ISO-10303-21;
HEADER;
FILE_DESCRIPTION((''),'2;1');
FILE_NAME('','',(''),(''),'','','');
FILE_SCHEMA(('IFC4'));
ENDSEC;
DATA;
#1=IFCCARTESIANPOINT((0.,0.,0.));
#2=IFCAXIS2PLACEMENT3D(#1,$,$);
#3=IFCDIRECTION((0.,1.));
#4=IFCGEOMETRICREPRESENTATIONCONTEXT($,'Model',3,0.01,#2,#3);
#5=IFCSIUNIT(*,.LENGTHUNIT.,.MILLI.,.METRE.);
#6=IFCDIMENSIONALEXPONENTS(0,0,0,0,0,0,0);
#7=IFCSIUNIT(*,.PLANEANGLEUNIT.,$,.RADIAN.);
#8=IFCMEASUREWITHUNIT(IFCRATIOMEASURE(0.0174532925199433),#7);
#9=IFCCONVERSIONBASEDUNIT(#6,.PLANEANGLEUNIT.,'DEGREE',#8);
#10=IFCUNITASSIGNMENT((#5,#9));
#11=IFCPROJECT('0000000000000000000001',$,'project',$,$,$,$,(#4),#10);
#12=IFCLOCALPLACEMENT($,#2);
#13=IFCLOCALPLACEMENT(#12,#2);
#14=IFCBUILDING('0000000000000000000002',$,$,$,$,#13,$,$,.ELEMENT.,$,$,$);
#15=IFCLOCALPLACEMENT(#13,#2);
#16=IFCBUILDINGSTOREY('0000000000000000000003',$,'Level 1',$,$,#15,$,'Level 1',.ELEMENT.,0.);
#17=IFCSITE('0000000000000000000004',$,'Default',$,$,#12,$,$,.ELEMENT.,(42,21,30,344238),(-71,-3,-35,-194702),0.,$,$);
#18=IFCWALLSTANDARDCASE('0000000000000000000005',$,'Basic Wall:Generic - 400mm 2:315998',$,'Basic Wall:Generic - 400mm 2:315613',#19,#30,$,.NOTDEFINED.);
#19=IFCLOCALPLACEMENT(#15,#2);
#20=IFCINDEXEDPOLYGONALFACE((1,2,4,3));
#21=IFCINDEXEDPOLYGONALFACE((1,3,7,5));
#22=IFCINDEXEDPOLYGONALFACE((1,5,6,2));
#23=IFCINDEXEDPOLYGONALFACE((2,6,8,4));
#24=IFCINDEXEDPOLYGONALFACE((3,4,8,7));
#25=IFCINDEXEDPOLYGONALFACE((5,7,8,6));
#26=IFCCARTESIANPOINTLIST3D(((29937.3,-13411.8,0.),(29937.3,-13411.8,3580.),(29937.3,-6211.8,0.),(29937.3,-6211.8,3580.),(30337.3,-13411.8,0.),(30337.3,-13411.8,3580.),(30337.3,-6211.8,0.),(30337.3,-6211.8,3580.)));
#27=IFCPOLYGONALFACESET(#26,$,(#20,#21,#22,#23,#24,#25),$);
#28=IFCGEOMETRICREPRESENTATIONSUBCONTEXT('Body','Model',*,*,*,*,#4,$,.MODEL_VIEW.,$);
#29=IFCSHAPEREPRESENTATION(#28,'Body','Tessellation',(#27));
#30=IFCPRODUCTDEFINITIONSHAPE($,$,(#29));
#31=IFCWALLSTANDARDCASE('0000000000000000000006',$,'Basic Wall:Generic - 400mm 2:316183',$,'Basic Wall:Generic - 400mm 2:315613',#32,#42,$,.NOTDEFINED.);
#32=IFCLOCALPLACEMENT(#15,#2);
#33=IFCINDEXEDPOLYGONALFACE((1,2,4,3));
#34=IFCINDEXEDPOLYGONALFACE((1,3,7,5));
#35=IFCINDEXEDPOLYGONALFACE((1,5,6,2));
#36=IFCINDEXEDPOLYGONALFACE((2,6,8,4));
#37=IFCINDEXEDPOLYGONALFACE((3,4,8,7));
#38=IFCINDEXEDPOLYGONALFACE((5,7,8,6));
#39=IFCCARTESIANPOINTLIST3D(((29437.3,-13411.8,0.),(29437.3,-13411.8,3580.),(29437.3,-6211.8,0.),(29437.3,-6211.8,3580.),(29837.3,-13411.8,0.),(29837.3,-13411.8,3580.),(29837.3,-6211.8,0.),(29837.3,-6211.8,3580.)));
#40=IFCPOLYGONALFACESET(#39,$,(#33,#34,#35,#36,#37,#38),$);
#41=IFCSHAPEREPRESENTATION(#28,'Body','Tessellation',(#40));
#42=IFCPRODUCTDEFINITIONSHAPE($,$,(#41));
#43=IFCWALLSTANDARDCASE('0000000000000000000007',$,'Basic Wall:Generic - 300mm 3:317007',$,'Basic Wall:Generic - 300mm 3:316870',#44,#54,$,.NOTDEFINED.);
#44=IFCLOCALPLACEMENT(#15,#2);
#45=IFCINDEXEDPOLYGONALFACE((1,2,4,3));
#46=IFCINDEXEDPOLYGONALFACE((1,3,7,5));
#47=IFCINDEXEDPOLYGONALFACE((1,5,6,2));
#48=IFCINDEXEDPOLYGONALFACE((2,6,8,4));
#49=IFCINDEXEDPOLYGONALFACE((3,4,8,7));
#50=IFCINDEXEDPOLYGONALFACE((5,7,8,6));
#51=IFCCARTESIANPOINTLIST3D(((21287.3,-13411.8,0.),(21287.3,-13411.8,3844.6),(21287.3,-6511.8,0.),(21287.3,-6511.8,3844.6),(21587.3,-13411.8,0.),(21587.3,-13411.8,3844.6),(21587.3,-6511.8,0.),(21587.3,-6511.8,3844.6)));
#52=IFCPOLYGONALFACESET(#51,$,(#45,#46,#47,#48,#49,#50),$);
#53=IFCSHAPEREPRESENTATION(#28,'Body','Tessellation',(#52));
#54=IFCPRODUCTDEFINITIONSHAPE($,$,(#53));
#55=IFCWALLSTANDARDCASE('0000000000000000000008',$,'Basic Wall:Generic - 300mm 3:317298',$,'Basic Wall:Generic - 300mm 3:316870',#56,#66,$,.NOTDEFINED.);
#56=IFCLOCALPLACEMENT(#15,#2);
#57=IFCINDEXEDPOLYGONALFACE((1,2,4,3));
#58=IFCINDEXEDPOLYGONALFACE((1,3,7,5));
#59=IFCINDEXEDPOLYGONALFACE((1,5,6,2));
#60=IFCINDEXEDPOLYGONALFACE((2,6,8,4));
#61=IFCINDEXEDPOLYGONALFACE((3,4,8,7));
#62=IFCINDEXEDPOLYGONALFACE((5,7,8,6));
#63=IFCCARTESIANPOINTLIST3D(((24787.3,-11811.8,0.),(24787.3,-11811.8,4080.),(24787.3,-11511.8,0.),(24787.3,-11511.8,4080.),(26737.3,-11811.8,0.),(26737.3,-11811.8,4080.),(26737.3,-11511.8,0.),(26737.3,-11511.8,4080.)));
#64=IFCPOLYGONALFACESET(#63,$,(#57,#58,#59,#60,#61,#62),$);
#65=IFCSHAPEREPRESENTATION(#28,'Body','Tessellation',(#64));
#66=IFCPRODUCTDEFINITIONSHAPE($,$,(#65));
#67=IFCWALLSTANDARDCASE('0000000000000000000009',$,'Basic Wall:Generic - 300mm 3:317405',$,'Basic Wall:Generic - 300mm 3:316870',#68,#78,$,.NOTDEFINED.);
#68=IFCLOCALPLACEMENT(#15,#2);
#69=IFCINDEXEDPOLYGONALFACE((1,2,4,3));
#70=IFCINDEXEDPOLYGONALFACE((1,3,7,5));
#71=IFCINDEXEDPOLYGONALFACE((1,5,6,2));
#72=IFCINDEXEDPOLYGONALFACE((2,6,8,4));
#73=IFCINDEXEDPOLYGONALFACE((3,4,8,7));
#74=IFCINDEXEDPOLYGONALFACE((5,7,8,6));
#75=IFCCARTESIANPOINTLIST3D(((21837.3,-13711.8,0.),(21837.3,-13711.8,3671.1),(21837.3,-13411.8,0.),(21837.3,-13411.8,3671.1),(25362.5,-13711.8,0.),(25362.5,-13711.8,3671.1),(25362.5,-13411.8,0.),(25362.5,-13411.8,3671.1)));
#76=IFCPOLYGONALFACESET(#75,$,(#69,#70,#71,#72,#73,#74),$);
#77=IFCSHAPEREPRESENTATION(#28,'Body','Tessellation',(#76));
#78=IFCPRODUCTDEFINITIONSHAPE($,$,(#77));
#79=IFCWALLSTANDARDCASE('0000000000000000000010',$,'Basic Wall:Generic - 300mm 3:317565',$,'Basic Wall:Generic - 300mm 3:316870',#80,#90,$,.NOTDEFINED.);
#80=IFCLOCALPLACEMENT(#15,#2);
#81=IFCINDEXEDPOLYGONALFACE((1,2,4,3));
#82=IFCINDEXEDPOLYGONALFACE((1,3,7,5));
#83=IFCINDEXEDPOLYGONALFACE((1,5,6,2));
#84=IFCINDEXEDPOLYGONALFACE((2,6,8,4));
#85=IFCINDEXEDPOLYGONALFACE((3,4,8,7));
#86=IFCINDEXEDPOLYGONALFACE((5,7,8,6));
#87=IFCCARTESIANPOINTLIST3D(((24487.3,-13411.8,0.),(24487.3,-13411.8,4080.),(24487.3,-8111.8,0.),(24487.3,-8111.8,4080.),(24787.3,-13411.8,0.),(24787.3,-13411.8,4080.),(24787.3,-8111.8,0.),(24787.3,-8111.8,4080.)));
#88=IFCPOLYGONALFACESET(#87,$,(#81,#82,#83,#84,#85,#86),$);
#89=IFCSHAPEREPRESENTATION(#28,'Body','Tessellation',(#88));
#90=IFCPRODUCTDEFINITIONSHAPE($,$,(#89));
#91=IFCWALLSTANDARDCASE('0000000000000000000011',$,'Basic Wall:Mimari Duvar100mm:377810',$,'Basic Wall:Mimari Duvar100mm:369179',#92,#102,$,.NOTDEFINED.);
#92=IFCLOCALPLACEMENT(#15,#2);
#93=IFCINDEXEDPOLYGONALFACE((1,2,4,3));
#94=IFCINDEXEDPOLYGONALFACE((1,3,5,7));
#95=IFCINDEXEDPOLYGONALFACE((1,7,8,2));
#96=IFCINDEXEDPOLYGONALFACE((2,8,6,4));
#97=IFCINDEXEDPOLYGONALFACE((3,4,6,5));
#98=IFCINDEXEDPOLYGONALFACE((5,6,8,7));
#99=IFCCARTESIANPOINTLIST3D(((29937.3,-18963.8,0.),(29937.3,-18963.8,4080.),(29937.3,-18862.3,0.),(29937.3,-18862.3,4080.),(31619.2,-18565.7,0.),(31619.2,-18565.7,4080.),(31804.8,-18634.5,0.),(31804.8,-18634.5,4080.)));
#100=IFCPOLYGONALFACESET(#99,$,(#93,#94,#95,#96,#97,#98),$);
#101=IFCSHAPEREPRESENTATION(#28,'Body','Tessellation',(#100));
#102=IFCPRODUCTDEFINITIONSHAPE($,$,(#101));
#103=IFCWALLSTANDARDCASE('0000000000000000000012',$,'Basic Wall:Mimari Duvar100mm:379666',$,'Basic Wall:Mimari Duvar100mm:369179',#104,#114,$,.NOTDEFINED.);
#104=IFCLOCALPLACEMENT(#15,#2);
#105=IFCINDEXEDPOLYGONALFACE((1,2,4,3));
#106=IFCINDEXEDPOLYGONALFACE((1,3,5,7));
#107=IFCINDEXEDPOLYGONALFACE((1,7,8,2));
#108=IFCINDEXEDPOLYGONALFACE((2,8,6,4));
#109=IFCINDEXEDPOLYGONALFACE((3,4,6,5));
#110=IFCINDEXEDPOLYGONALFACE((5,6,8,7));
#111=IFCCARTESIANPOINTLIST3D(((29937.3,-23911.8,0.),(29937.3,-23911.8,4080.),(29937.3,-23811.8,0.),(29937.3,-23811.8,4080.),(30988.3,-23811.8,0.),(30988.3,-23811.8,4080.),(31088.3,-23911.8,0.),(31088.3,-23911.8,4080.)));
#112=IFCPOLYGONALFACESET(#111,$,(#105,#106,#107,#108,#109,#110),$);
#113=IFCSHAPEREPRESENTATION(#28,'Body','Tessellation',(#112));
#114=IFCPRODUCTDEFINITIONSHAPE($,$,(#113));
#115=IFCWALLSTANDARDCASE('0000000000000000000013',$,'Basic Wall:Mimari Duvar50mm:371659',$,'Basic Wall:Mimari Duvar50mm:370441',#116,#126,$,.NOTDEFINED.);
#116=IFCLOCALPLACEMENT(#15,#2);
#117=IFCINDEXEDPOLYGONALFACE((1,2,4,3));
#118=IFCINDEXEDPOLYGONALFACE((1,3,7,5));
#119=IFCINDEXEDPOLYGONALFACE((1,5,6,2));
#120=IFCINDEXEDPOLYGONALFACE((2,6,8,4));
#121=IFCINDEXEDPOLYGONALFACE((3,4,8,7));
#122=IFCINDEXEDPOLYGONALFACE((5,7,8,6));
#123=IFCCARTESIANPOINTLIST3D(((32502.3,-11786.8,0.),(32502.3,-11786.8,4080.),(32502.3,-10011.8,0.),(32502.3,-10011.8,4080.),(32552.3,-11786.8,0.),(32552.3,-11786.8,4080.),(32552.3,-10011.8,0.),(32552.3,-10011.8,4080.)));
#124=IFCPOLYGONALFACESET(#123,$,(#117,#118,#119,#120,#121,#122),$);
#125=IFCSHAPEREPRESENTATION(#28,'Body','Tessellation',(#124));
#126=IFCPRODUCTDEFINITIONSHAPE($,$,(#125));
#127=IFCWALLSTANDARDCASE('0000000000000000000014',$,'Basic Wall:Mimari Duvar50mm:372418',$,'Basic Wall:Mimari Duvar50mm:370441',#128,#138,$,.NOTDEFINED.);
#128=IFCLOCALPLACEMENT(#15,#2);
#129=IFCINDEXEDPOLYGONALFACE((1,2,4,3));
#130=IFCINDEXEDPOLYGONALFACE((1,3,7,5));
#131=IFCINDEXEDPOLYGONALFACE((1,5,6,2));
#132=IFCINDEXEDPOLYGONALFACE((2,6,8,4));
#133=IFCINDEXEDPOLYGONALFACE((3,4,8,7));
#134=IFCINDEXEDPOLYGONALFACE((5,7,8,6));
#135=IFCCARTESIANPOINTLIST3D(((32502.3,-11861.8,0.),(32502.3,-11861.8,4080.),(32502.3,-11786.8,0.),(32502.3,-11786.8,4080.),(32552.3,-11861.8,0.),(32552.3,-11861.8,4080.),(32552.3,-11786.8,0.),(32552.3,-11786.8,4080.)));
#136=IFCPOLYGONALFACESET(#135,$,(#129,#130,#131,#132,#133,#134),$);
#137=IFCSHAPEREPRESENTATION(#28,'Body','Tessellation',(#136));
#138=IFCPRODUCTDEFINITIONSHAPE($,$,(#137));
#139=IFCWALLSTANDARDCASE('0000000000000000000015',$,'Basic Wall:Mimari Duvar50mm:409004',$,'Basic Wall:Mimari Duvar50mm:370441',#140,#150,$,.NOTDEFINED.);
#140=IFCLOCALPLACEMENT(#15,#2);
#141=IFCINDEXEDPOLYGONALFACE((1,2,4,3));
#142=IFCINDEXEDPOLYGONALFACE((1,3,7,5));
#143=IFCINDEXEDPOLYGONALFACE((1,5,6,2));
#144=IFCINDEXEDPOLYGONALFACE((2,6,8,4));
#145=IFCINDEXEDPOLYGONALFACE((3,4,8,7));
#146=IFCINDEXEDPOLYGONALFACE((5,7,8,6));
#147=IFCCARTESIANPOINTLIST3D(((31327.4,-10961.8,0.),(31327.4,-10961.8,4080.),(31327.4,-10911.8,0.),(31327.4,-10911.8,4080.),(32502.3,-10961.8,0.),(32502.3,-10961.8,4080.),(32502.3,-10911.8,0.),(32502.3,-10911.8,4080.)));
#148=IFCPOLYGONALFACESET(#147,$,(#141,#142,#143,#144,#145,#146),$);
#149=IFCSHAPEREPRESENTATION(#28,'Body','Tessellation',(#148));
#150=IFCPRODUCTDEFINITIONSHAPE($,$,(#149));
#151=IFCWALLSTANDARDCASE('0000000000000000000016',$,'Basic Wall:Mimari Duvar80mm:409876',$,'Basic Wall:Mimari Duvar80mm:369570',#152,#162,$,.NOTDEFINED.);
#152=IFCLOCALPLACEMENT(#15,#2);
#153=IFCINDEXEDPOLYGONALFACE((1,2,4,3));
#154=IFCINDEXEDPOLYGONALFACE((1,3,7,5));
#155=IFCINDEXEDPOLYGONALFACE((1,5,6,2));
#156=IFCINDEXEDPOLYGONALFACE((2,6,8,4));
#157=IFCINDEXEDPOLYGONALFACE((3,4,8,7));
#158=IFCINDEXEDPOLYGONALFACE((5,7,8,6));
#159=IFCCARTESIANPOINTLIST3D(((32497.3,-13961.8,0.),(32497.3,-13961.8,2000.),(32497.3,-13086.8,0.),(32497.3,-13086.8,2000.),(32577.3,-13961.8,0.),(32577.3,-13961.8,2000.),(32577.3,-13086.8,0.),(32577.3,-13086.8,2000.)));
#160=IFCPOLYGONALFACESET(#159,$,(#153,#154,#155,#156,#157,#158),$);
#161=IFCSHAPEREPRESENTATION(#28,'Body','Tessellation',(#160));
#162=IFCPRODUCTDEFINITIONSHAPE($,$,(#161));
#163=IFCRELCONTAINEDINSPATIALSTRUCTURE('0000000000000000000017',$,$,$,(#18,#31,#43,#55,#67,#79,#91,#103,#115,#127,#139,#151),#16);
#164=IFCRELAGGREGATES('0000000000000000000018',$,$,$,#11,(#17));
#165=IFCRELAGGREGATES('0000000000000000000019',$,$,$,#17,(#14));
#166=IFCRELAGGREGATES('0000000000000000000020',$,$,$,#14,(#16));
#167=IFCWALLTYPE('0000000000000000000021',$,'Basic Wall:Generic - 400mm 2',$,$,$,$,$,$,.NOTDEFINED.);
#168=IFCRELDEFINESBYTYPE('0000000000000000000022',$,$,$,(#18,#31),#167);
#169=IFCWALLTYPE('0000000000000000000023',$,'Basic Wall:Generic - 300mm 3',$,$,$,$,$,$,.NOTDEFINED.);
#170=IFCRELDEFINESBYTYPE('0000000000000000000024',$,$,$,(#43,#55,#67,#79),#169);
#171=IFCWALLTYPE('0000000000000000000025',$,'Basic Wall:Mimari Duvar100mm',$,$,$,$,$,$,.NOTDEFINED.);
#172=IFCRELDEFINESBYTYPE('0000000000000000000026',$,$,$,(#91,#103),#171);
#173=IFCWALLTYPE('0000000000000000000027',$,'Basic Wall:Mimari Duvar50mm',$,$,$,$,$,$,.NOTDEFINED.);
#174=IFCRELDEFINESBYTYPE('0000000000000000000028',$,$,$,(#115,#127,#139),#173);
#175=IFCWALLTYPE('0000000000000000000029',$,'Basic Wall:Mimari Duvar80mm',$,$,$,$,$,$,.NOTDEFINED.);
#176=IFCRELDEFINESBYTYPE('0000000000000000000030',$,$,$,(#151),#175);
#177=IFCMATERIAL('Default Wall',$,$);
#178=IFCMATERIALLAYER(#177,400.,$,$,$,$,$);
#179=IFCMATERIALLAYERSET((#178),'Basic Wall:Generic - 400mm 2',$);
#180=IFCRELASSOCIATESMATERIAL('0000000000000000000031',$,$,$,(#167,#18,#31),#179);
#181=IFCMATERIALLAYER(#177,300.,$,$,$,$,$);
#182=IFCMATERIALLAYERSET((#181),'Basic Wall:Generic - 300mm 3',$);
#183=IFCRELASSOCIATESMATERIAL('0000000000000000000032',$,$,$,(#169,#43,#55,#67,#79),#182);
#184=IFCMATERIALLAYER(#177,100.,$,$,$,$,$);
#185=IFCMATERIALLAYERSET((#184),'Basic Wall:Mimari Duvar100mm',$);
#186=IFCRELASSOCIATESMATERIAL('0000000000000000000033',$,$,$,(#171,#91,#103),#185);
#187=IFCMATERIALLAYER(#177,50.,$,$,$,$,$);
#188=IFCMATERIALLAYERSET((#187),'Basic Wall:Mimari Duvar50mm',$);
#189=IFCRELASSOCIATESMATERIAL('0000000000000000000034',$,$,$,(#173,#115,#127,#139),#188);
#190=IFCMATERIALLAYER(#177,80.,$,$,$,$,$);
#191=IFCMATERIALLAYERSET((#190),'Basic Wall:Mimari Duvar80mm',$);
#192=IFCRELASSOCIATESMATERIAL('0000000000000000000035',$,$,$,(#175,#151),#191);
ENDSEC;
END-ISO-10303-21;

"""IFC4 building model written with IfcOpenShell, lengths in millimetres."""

from ifc_helpers import new_model, entity, si_unit, converted_unit, direction, frame, frame_2d, origin, place, context, subcontext, project, spatial, polyline, rectangle, outline, extrude, material, layer, layer_set, layer_usage, type_object, element, save


model = new_model("IFC4")

# Units and contexts
model_context = context("Model", 3, precision=0.01, world=origin(), true_north=direction((0.0, 1.0)))
body_context = subcontext(model_context, "Body", "Model", "MODEL_VIEW")
ifc_project = project(units=[si_unit("LENGTHUNIT", "METRE", prefix="MILLI"), converted_unit("PLANEANGLEUNIT", "DEGREE", entity("IfcRatioMeasure", 0.0174532925199433), si_unit("PLANEANGLEUNIT", "RADIAN"), dimensions=[0, 0, 0, 0, 0, 0, 0])], contexts=[model_context])

# Site, building, storey
site_placement = place(None, origin())
site = spatial("IfcSite", under=ifc_project, at=site_placement, Name="Default", CompositionType="ELEMENT", RefLatitude=(42, 21, 30, 344238), RefLongitude=(-71, -3, -35, -194702), RefElevation=0.0)
building_placement = place(site_placement, origin())
building = spatial("IfcBuilding", under=site, at=building_placement, CompositionType="ELEMENT")
storey_placement = place(building_placement, origin())
storey = spatial("IfcBuildingStorey", under=building, at=storey_placement, Name="Level 1", LongName="Level 1", CompositionType="ELEMENT", Elevation=0.0)

# Walls
ifc_material_1 = material(Name="Default Wall")
ifc_layer_1 = layer(ifc_material_1, 400.0)
ifc_layer_set_1 = layer_set([ifc_layer_1], Name="Basic Wall:Generic - 400mm 2")
ifc_layer_usage_1 = layer_usage(ifc_layer_set_1, "AXIS2", "NEGATIVE", 200.0)
wall_type_1 = type_object("IfcWallType", Name="Basic Wall:Generic - 400mm 2", PredefinedType="NOTDEFINED", material=ifc_layer_set_1)
wall_1_placement = place(storey_placement, frame((30137.3, -13411.8, 0.0), z_axis=(0.0, 0.0, 1.0), x_axis=(0.0, 1.0, 0.0)))
element("IfcWallStandardCase", 1, at=wall_1_placement, inside=storey, type_object=wall_type_1, material=ifc_layer_usage_1, Name="Basic Wall:Generic - 400mm 2:315998", ObjectType="Basic Wall:Generic - 400mm 2:315613", PredefinedType="NOTDEFINED", context=body_context, shape_type="SweptSolid", body=[
    extrude(rectangle(XDim=7200.0, YDim=400.0, at=frame_2d((3600.0, 0.0), x_axis=(-1.0, 0.0))), origin(), (0.0, 0.0, 1.0), 3580.0),
])
ifc_layer_usage_2 = layer_usage(ifc_layer_set_1, "AXIS2", "NEGATIVE", 200.0)
wall_2_placement = place(storey_placement, frame((29637.3, -13411.8, 0.0), z_axis=(0.0, 0.0, 1.0), x_axis=(0.0, 1.0, 0.0)))
element("IfcWallStandardCase", 2, at=wall_2_placement, inside=storey, type_object=wall_type_1, material=ifc_layer_usage_2, Name="Basic Wall:Generic - 400mm 2:316183", ObjectType="Basic Wall:Generic - 400mm 2:315613", PredefinedType="NOTDEFINED", context=body_context, shape_type="SweptSolid", body=[
    extrude(rectangle(XDim=7200.0, YDim=400.0, at=frame_2d((3600.0, 0.0), x_axis=(-1.0, 0.0))), origin(), (0.0, 0.0, 1.0), 3580.0),
])
ifc_layer_2 = layer(ifc_material_1, 300.0)
ifc_layer_set_2 = layer_set([ifc_layer_2], Name="Basic Wall:Generic - 300mm 3")
ifc_layer_usage_3 = layer_usage(ifc_layer_set_2, "AXIS2", "NEGATIVE", 150.0)
wall_type_2 = type_object("IfcWallType", Name="Basic Wall:Generic - 300mm 3", PredefinedType="NOTDEFINED", material=ifc_layer_set_2)
wall_3_placement = place(storey_placement, frame((21437.3, -13411.8, 0.0), z_axis=(0.0, 0.0, 1.0), x_axis=(0.0, 1.0, 0.0)))
element("IfcWallStandardCase", 3, at=wall_3_placement, inside=storey, type_object=wall_type_2, material=ifc_layer_usage_3, Name="Basic Wall:Generic - 300mm 3:317007", ObjectType="Basic Wall:Generic - 300mm 3:316870", PredefinedType="NOTDEFINED", context=body_context, shape_type="SweptSolid", body=[
    extrude(rectangle(XDim=6900.0, YDim=300.0, at=frame_2d((3450.0, 0.0), x_axis=(-1.0, 0.0))), origin(), (0.0, 0.0, 1.0), 3844.6),
])
ifc_layer_usage_4 = layer_usage(ifc_layer_set_2, "AXIS2", "NEGATIVE", 150.0)
wall_4_placement = place(storey_placement, frame((26737.3, -11661.8, 0.0), z_axis=(0.0, 0.0, 1.0), x_axis=(-1.0, 0.0, 0.0)))
element("IfcWallStandardCase", 4, at=wall_4_placement, inside=storey, type_object=wall_type_2, material=ifc_layer_usage_4, Name="Basic Wall:Generic - 300mm 3:317298", ObjectType="Basic Wall:Generic - 300mm 3:316870", PredefinedType="NOTDEFINED", context=body_context, shape_type="SweptSolid", body=[
    extrude(rectangle(XDim=1950.0, YDim=300.0, at=frame_2d((975.0, 0.0), x_axis=(-1.0, 0.0))), origin(), (0.0, 0.0, 1.0), 4080.0),
])
ifc_layer_usage_5 = layer_usage(ifc_layer_set_2, "AXIS2", "NEGATIVE", 150.0)
wall_5_placement = place(storey_placement, frame((25362.5, -13561.8, 0.0), z_axis=(0.0, 0.0, 1.0), x_axis=(-1.0, 0.0, 0.0)))
element("IfcWallStandardCase", 5, at=wall_5_placement, inside=storey, type_object=wall_type_2, material=ifc_layer_usage_5, Name="Basic Wall:Generic - 300mm 3:317405", ObjectType="Basic Wall:Generic - 300mm 3:316870", PredefinedType="NOTDEFINED", context=body_context, shape_type="SweptSolid", body=[
    extrude(rectangle(XDim=3525.2, YDim=300.0, at=frame_2d((1762.6, 0.0), x_axis=(-1.0, 0.0))), origin(), (0.0, 0.0, 1.0), 3671.1),
])
ifc_layer_usage_6 = layer_usage(ifc_layer_set_2, "AXIS2", "NEGATIVE", 150.0)
wall_6_placement = place(storey_placement, frame((24637.3, -13411.8, 0.0), z_axis=(0.0, 0.0, 1.0), x_axis=(0.0, 1.0, 0.0)))
element("IfcWallStandardCase", 6, at=wall_6_placement, inside=storey, type_object=wall_type_2, material=ifc_layer_usage_6, Name="Basic Wall:Generic - 300mm 3:317565", ObjectType="Basic Wall:Generic - 300mm 3:316870", PredefinedType="NOTDEFINED", context=body_context, shape_type="SweptSolid", body=[
    extrude(rectangle(XDim=5300.0, YDim=300.0, at=frame_2d((2650.0, 0.0), x_axis=(-1.0, 0.0))), origin(), (0.0, 0.0, 1.0), 4080.0),
])
ifc_layer_3 = layer(ifc_material_1, 100.0)
ifc_layer_set_3 = layer_set([ifc_layer_3], Name="Basic Wall:Mimari Duvar100mm")
ifc_layer_usage_7 = layer_usage(ifc_layer_set_3, "AXIS2", "NEGATIVE", 50.0)
wall_type_3 = type_object("IfcWallType", Name="Basic Wall:Mimari Duvar100mm", PredefinedType="NOTDEFINED", material=ifc_layer_set_3)
wall_7_placement = place(storey_placement, frame((31796.2, -18585.3, 0.0), z_axis=(0.0, 0.0, 1.0), x_axis=(-0.984808, -0.173648, 0.0)))
element("IfcWallStandardCase", 7, at=wall_7_placement, inside=storey, type_object=wall_type_3, material=ifc_layer_usage_7, Name="Basic Wall:Mimari Duvar100mm:377810", ObjectType="Basic Wall:Mimari Duvar100mm:369179", PredefinedType="NOTDEFINED", context=body_context, shape_type="SweptSolid", body=[
    extrude(outline(polyline([(1878.8, -50.0), (1896.4, 50.0), (0.0, 50.0), (170.9, -50.0), (1878.8, -50.0)])), origin(), (0.0, 0.0, 1.0), 4080.0),
])
ifc_layer_usage_8 = layer_usage(ifc_layer_set_3, "AXIS2", "NEGATIVE", 50.0)
wall_8_placement = place(storey_placement, frame((29937.3, -23861.8, 0.0)))
element("IfcWallStandardCase", 8, at=wall_8_placement, inside=storey, type_object=wall_type_3, material=ifc_layer_usage_8, Name="Basic Wall:Mimari Duvar100mm:379666", ObjectType="Basic Wall:Mimari Duvar100mm:369179", PredefinedType="NOTDEFINED", context=body_context, shape_type="SweptSolid", body=[
    extrude(outline(polyline([(1151.0, -50.0), (1051.0, 50.0), (0.0, 50.0), (0.0, -50.0), (1151.0, -50.0)])), origin(), (0.0, 0.0, 1.0), 4080.0),
])
ifc_layer_4 = layer(ifc_material_1, 50.0)
ifc_layer_set_4 = layer_set([ifc_layer_4], Name="Basic Wall:Mimari Duvar50mm")
ifc_layer_usage_9 = layer_usage(ifc_layer_set_4, "AXIS2", "NEGATIVE", 25.0)
wall_type_4 = type_object("IfcWallType", Name="Basic Wall:Mimari Duvar50mm", PredefinedType="NOTDEFINED", material=ifc_layer_set_4)
wall_9_placement = place(storey_placement, frame((32527.3, -11786.8, 0.0), z_axis=(0.0, 0.0, 1.0), x_axis=(0.0, 1.0, 0.0)))
element("IfcWallStandardCase", 9, at=wall_9_placement, inside=storey, type_object=wall_type_4, material=ifc_layer_usage_9, Name="Basic Wall:Mimari Duvar50mm:371659", ObjectType="Basic Wall:Mimari Duvar50mm:370441", PredefinedType="NOTDEFINED", context=body_context, shape_type="SweptSolid", body=[
    extrude(rectangle(XDim=1775.0, YDim=50.0, at=frame_2d((887.5, 0.0), x_axis=(-1.0, 0.0))), origin(), (0.0, 0.0, 1.0), 4080.0),
])
ifc_layer_usage_10 = layer_usage(ifc_layer_set_4, "AXIS2", "NEGATIVE", 25.0)
wall_10_placement = place(storey_placement, frame((32527.3, -11786.8, 0.0), z_axis=(0.0, 0.0, 1.0), x_axis=(0.0, -1.0, 0.0)))
element("IfcWallStandardCase", 10, at=wall_10_placement, inside=storey, type_object=wall_type_4, material=ifc_layer_usage_10, Name="Basic Wall:Mimari Duvar50mm:372418", ObjectType="Basic Wall:Mimari Duvar50mm:370441", PredefinedType="NOTDEFINED", context=body_context, shape_type="SweptSolid", body=[
    extrude(rectangle(XDim=75.0, YDim=50.0, at=frame_2d((37.5, 0.0), x_axis=(-1.0, 0.0))), origin(), (0.0, 0.0, 1.0), 4080.0),
])
ifc_layer_usage_11 = layer_usage(ifc_layer_set_4, "AXIS2", "NEGATIVE", 25.0)
wall_11_placement = place(storey_placement, frame((32502.3, -10936.8, 0.0), z_axis=(0.0, 0.0, 1.0), x_axis=(-1.0, 0.0, 0.0)))
element("IfcWallStandardCase", 11, at=wall_11_placement, inside=storey, type_object=wall_type_4, material=ifc_layer_usage_11, Name="Basic Wall:Mimari Duvar50mm:409004", ObjectType="Basic Wall:Mimari Duvar50mm:370441", PredefinedType="NOTDEFINED", context=body_context, shape_type="SweptSolid", body=[
    extrude(rectangle(XDim=1174.9, YDim=50.0, at=frame_2d((587.5, 0.0), x_axis=(-1.0, 0.0))), origin(), (0.0, 0.0, 1.0), 4080.0),
])
ifc_layer_5 = layer(ifc_material_1, 80.0)
ifc_layer_set_5 = layer_set([ifc_layer_5], Name="Basic Wall:Mimari Duvar80mm")
ifc_layer_usage_12 = layer_usage(ifc_layer_set_5, "AXIS2", "NEGATIVE", 40.0)
wall_type_5 = type_object("IfcWallType", Name="Basic Wall:Mimari Duvar80mm", PredefinedType="NOTDEFINED", material=ifc_layer_set_5)
wall_12_placement = place(storey_placement, frame((32537.3, -13086.8, 0.0), z_axis=(0.0, 0.0, 1.0), x_axis=(0.0, -1.0, 0.0)))
element("IfcWallStandardCase", 12, at=wall_12_placement, inside=storey, type_object=wall_type_5, material=ifc_layer_usage_12, Name="Basic Wall:Mimari Duvar80mm:409876", ObjectType="Basic Wall:Mimari Duvar80mm:369570", PredefinedType="NOTDEFINED", context=body_context, shape_type="SweptSolid", body=[
    extrude(rectangle(XDim=875.0, YDim=80.0, at=frame_2d((437.5, 0.0), x_axis=(-1.0, 0.0))), origin(), (0.0, 0.0, 1.0), 2000.0),
])

save(model, "model.ifc")
